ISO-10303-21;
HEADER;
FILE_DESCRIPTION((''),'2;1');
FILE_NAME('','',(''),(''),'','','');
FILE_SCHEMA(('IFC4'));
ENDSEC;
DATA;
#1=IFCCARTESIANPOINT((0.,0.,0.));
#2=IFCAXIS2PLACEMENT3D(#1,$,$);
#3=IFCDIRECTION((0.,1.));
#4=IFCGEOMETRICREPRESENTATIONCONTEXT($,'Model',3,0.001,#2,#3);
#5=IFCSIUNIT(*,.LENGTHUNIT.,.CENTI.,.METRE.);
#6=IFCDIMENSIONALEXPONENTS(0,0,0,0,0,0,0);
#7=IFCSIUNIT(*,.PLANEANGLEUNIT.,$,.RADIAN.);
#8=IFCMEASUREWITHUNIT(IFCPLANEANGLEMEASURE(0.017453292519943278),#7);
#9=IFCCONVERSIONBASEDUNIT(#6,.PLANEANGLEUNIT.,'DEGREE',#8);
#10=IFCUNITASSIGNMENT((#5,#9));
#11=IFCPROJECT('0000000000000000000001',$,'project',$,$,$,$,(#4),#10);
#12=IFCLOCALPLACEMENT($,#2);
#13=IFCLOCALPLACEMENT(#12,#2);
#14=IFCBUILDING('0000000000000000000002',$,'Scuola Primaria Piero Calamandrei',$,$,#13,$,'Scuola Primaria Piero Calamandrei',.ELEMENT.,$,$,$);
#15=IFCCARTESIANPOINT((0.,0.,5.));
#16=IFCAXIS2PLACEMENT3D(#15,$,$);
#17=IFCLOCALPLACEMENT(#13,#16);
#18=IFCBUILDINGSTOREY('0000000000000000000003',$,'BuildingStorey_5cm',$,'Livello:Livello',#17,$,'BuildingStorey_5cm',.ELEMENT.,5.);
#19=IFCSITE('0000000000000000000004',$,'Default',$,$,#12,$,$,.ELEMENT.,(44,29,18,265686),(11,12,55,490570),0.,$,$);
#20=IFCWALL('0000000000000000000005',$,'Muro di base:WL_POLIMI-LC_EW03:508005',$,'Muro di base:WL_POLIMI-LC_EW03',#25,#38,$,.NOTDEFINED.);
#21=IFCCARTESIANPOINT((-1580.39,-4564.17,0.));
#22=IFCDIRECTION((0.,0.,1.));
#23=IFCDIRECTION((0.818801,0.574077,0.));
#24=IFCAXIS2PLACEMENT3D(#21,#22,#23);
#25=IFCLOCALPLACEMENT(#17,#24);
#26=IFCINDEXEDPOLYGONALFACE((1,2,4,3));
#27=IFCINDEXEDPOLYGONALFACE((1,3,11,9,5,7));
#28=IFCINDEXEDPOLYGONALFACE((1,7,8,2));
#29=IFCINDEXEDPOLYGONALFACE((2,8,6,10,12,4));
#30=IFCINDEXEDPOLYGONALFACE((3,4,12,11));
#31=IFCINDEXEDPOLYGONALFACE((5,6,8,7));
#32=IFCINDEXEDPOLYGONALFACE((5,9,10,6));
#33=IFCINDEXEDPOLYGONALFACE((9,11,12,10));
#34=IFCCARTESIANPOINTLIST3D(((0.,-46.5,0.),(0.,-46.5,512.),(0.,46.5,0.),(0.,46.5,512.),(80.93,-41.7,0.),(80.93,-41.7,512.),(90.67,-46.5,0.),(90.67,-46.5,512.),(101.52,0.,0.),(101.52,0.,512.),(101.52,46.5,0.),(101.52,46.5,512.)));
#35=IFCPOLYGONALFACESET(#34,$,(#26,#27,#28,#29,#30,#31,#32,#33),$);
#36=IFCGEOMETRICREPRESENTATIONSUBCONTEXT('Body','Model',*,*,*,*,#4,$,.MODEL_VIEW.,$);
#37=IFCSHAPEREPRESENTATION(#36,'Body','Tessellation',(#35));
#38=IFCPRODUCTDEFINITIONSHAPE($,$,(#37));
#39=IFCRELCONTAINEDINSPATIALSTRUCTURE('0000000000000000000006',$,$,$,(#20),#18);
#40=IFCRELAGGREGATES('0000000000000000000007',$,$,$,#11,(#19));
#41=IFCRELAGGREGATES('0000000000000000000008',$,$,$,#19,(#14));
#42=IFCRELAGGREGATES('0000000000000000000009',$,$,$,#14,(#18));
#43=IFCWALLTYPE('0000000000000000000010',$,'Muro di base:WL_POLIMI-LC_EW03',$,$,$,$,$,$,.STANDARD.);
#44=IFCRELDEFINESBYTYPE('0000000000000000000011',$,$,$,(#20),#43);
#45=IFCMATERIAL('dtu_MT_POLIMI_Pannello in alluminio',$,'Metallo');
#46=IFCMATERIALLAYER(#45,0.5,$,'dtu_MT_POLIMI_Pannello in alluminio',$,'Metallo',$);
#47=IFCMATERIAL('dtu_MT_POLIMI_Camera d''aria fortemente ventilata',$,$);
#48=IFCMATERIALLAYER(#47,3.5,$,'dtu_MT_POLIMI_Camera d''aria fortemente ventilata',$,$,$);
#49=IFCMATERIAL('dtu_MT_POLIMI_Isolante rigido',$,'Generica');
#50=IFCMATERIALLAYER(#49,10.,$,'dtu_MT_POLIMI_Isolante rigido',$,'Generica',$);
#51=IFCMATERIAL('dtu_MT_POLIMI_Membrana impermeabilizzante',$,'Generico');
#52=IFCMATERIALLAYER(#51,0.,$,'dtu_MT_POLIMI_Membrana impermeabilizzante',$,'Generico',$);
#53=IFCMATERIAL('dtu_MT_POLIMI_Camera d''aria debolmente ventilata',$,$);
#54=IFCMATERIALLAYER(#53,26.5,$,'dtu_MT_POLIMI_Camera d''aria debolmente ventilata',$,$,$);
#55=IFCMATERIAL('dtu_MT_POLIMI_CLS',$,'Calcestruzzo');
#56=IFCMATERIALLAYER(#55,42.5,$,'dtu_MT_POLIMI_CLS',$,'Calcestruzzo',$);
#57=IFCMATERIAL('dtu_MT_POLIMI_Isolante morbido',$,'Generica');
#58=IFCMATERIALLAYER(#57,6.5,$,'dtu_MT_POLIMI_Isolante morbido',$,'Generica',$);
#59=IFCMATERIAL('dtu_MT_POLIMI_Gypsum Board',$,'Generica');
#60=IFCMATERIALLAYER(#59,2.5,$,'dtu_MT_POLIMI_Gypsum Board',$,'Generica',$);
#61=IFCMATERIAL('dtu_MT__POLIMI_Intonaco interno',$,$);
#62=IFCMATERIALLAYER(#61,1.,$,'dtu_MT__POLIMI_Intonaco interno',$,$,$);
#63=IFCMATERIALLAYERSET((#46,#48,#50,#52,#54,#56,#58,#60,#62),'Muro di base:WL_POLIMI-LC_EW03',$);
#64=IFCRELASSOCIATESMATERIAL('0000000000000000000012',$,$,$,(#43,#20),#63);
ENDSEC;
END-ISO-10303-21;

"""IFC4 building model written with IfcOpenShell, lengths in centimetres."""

from ifc_helpers import new_model, entity, si_unit, converted_unit, direction, frame, frame_2d, origin, place, context, subcontext, project, spatial, polyline, rectangle, extrude, clip, bounded_halfspace, material, layer, layer_set, layer_usage, type_object, element, save


model = new_model("IFC4")

# Units and contexts
model_context = context("Model", 3, precision=0.001, world=origin(), true_north=direction((0.0, 1.0)))
body_context = subcontext(model_context, "Body", "Model", "MODEL_VIEW")
ifc_project = project(units=[si_unit("LENGTHUNIT", "METRE", prefix="CENTI"), converted_unit("PLANEANGLEUNIT", "DEGREE", entity("IfcPlaneAngleMeasure", 0.017453292519943278), si_unit("PLANEANGLEUNIT", "RADIAN"), dimensions=[0, 0, 0, 0, 0, 0, 0])], contexts=[model_context])

# Site, building, storey
site_placement = place(None, origin())
site = spatial("IfcSite", under=ifc_project, at=site_placement, Name="Default", CompositionType="ELEMENT", RefLatitude=(44, 29, 18, 265686), RefLongitude=(11, 12, 55, 490570), RefElevation=0.0)
building_placement = place(site_placement, origin())
building = spatial("IfcBuilding", under=site, at=building_placement, Name="Scuola Primaria Piero Calamandrei", LongName="Scuola Primaria Piero Calamandrei", CompositionType="ELEMENT")
storey_placement = place(building_placement, frame((0.0, 0.0, 5.0)))
storey = spatial("IfcBuildingStorey", under=building, at=storey_placement, Name="BuildingStorey_5cm", ObjectType="Livello:Livello", LongName="BuildingStorey_5cm", CompositionType="ELEMENT", Elevation=5.0)

# Shared definitions
ifc_material_1 = material(Name="dtu_MT_POLIMI_Isolante rigido", Category="Generica")
ifc_material_2 = material(Name="dtu_MT_POLIMI_CLS", Category="Calcestruzzo")

# Wall
ifc_material_3 = material(Name="dtu_MT_POLIMI_Pannello in alluminio", Category="Metallo")
ifc_material_4 = material(Name="dtu_MT_POLIMI_Camera d'aria fortemente ventilata")
ifc_material_5 = material(Name="dtu_MT_POLIMI_Membrana impermeabilizzante", Category="Generico")
ifc_material_6 = material(Name="dtu_MT_POLIMI_Camera d'aria debolmente ventilata")
ifc_material_7 = material(Name="dtu_MT__POLIMI_Intonaco interno")
ifc_layer_1 = layer(ifc_material_3, 0.5, Name="dtu_MT_POLIMI_Pannello in alluminio", Category="Metallo")
ifc_layer_2 = layer(ifc_material_4, 3.5, Name="dtu_MT_POLIMI_Camera d'aria fortemente ventilata")
ifc_layer_3 = layer(ifc_material_1, 10.0, Name="dtu_MT_POLIMI_Isolante rigido", Category="Generica")
ifc_layer_4 = layer(ifc_material_5, 0.0, Name="dtu_MT_POLIMI_Membrana impermeabilizzante", Category="Generico")
ifc_layer_5 = layer(ifc_material_6, 26.5, Name="dtu_MT_POLIMI_Camera d'aria debolmente ventilata")
ifc_layer_6 = layer(ifc_material_2, 42.5, Name="dtu_MT_POLIMI_CLS", Category="Calcestruzzo")
ifc_material_8 = material(Name="dtu_MT_POLIMI_Isolante morbido", Category="Generica")
ifc_layer_7 = layer(ifc_material_8, 6.5, Name="dtu_MT_POLIMI_Isolante morbido", Category="Generica")
ifc_material_9 = material(Name="dtu_MT_POLIMI_Gypsum Board", Category="Generica")
ifc_layer_8 = layer(ifc_material_9, 2.5, Name="dtu_MT_POLIMI_Gypsum Board", Category="Generica")
ifc_layer_9 = layer(ifc_material_7, 1.0, Name="dtu_MT__POLIMI_Intonaco interno")
ifc_layer_set_1 = layer_set([ifc_layer_1, ifc_layer_2, ifc_layer_3, ifc_layer_4, ifc_layer_5, ifc_layer_6, ifc_layer_7, ifc_layer_8, ifc_layer_9], Name="Muro di base:WL_POLIMI-LC_EW03")
wall_type_1 = type_object("IfcWallType", Name="Muro di base:WL_POLIMI-LC_EW03", PredefinedType="STANDARD", material=ifc_layer_set_1)
ifc_layer_usage_1 = layer_usage(ifc_layer_set_1, "AXIS2", "NEGATIVE", 46.5)
wall_1_placement = place(storey_placement, frame((-1580.39, -4564.17, 0.0), z_axis=(0.0, 0.0, 1.0), x_axis=(0.818801, 0.574077, 0.0)))
element("IfcWall", 1, at=wall_1_placement, inside=storey, type_object=wall_type_1, material=ifc_layer_usage_1, Name="Muro di base:WL_POLIMI-LC_EW03:508005", ObjectType="Muro di base:WL_POLIMI-LC_EW03", PredefinedType="NOTDEFINED", context=body_context, shape_type="Clipping", body=[
    clip(clip(extrude(rectangle(XDim=101.52, YDim=93.0, at=frame_2d((50.76, 0.0), x_axis=(-1.0, 0.0))), origin(), (0.0, 0.0, 1.0), 512.0), bounded_halfspace(frame((80.93, -41.7, 0.0), z_axis=(-0.442682, -0.896679, 0.0), x_axis=(0.896679, -0.442682, 0.0)), True, frame((80.93, -41.7, 0.0), z_axis=(-0.442682, -0.896679, 0.0), x_axis=(0.896679, -0.442682, 0.0)), polyline([(0.0, 0.0), (330.8, 0.0), (330.8, 15605.76), (0.0, 15605.76), (0.0, 0.0)]))), bounded_halfspace(frame((80.93, -41.7, 512.0), z_axis=(-0.896679, 0.442682, 0.0), x_axis=(0.442682, 0.896679, 0.0)), True, frame((80.93, -41.7, 512.0), z_axis=(-0.896679, 0.442682, 0.0), x_axis=(0.442682, 0.896679, 0.0)), polyline([(0.0, 0.0), (1417.32, 0.0), (1417.32, 15605.76), (0.0, 15605.76), (0.0, 0.0)]))),
])

save(model, "model.ifc")
